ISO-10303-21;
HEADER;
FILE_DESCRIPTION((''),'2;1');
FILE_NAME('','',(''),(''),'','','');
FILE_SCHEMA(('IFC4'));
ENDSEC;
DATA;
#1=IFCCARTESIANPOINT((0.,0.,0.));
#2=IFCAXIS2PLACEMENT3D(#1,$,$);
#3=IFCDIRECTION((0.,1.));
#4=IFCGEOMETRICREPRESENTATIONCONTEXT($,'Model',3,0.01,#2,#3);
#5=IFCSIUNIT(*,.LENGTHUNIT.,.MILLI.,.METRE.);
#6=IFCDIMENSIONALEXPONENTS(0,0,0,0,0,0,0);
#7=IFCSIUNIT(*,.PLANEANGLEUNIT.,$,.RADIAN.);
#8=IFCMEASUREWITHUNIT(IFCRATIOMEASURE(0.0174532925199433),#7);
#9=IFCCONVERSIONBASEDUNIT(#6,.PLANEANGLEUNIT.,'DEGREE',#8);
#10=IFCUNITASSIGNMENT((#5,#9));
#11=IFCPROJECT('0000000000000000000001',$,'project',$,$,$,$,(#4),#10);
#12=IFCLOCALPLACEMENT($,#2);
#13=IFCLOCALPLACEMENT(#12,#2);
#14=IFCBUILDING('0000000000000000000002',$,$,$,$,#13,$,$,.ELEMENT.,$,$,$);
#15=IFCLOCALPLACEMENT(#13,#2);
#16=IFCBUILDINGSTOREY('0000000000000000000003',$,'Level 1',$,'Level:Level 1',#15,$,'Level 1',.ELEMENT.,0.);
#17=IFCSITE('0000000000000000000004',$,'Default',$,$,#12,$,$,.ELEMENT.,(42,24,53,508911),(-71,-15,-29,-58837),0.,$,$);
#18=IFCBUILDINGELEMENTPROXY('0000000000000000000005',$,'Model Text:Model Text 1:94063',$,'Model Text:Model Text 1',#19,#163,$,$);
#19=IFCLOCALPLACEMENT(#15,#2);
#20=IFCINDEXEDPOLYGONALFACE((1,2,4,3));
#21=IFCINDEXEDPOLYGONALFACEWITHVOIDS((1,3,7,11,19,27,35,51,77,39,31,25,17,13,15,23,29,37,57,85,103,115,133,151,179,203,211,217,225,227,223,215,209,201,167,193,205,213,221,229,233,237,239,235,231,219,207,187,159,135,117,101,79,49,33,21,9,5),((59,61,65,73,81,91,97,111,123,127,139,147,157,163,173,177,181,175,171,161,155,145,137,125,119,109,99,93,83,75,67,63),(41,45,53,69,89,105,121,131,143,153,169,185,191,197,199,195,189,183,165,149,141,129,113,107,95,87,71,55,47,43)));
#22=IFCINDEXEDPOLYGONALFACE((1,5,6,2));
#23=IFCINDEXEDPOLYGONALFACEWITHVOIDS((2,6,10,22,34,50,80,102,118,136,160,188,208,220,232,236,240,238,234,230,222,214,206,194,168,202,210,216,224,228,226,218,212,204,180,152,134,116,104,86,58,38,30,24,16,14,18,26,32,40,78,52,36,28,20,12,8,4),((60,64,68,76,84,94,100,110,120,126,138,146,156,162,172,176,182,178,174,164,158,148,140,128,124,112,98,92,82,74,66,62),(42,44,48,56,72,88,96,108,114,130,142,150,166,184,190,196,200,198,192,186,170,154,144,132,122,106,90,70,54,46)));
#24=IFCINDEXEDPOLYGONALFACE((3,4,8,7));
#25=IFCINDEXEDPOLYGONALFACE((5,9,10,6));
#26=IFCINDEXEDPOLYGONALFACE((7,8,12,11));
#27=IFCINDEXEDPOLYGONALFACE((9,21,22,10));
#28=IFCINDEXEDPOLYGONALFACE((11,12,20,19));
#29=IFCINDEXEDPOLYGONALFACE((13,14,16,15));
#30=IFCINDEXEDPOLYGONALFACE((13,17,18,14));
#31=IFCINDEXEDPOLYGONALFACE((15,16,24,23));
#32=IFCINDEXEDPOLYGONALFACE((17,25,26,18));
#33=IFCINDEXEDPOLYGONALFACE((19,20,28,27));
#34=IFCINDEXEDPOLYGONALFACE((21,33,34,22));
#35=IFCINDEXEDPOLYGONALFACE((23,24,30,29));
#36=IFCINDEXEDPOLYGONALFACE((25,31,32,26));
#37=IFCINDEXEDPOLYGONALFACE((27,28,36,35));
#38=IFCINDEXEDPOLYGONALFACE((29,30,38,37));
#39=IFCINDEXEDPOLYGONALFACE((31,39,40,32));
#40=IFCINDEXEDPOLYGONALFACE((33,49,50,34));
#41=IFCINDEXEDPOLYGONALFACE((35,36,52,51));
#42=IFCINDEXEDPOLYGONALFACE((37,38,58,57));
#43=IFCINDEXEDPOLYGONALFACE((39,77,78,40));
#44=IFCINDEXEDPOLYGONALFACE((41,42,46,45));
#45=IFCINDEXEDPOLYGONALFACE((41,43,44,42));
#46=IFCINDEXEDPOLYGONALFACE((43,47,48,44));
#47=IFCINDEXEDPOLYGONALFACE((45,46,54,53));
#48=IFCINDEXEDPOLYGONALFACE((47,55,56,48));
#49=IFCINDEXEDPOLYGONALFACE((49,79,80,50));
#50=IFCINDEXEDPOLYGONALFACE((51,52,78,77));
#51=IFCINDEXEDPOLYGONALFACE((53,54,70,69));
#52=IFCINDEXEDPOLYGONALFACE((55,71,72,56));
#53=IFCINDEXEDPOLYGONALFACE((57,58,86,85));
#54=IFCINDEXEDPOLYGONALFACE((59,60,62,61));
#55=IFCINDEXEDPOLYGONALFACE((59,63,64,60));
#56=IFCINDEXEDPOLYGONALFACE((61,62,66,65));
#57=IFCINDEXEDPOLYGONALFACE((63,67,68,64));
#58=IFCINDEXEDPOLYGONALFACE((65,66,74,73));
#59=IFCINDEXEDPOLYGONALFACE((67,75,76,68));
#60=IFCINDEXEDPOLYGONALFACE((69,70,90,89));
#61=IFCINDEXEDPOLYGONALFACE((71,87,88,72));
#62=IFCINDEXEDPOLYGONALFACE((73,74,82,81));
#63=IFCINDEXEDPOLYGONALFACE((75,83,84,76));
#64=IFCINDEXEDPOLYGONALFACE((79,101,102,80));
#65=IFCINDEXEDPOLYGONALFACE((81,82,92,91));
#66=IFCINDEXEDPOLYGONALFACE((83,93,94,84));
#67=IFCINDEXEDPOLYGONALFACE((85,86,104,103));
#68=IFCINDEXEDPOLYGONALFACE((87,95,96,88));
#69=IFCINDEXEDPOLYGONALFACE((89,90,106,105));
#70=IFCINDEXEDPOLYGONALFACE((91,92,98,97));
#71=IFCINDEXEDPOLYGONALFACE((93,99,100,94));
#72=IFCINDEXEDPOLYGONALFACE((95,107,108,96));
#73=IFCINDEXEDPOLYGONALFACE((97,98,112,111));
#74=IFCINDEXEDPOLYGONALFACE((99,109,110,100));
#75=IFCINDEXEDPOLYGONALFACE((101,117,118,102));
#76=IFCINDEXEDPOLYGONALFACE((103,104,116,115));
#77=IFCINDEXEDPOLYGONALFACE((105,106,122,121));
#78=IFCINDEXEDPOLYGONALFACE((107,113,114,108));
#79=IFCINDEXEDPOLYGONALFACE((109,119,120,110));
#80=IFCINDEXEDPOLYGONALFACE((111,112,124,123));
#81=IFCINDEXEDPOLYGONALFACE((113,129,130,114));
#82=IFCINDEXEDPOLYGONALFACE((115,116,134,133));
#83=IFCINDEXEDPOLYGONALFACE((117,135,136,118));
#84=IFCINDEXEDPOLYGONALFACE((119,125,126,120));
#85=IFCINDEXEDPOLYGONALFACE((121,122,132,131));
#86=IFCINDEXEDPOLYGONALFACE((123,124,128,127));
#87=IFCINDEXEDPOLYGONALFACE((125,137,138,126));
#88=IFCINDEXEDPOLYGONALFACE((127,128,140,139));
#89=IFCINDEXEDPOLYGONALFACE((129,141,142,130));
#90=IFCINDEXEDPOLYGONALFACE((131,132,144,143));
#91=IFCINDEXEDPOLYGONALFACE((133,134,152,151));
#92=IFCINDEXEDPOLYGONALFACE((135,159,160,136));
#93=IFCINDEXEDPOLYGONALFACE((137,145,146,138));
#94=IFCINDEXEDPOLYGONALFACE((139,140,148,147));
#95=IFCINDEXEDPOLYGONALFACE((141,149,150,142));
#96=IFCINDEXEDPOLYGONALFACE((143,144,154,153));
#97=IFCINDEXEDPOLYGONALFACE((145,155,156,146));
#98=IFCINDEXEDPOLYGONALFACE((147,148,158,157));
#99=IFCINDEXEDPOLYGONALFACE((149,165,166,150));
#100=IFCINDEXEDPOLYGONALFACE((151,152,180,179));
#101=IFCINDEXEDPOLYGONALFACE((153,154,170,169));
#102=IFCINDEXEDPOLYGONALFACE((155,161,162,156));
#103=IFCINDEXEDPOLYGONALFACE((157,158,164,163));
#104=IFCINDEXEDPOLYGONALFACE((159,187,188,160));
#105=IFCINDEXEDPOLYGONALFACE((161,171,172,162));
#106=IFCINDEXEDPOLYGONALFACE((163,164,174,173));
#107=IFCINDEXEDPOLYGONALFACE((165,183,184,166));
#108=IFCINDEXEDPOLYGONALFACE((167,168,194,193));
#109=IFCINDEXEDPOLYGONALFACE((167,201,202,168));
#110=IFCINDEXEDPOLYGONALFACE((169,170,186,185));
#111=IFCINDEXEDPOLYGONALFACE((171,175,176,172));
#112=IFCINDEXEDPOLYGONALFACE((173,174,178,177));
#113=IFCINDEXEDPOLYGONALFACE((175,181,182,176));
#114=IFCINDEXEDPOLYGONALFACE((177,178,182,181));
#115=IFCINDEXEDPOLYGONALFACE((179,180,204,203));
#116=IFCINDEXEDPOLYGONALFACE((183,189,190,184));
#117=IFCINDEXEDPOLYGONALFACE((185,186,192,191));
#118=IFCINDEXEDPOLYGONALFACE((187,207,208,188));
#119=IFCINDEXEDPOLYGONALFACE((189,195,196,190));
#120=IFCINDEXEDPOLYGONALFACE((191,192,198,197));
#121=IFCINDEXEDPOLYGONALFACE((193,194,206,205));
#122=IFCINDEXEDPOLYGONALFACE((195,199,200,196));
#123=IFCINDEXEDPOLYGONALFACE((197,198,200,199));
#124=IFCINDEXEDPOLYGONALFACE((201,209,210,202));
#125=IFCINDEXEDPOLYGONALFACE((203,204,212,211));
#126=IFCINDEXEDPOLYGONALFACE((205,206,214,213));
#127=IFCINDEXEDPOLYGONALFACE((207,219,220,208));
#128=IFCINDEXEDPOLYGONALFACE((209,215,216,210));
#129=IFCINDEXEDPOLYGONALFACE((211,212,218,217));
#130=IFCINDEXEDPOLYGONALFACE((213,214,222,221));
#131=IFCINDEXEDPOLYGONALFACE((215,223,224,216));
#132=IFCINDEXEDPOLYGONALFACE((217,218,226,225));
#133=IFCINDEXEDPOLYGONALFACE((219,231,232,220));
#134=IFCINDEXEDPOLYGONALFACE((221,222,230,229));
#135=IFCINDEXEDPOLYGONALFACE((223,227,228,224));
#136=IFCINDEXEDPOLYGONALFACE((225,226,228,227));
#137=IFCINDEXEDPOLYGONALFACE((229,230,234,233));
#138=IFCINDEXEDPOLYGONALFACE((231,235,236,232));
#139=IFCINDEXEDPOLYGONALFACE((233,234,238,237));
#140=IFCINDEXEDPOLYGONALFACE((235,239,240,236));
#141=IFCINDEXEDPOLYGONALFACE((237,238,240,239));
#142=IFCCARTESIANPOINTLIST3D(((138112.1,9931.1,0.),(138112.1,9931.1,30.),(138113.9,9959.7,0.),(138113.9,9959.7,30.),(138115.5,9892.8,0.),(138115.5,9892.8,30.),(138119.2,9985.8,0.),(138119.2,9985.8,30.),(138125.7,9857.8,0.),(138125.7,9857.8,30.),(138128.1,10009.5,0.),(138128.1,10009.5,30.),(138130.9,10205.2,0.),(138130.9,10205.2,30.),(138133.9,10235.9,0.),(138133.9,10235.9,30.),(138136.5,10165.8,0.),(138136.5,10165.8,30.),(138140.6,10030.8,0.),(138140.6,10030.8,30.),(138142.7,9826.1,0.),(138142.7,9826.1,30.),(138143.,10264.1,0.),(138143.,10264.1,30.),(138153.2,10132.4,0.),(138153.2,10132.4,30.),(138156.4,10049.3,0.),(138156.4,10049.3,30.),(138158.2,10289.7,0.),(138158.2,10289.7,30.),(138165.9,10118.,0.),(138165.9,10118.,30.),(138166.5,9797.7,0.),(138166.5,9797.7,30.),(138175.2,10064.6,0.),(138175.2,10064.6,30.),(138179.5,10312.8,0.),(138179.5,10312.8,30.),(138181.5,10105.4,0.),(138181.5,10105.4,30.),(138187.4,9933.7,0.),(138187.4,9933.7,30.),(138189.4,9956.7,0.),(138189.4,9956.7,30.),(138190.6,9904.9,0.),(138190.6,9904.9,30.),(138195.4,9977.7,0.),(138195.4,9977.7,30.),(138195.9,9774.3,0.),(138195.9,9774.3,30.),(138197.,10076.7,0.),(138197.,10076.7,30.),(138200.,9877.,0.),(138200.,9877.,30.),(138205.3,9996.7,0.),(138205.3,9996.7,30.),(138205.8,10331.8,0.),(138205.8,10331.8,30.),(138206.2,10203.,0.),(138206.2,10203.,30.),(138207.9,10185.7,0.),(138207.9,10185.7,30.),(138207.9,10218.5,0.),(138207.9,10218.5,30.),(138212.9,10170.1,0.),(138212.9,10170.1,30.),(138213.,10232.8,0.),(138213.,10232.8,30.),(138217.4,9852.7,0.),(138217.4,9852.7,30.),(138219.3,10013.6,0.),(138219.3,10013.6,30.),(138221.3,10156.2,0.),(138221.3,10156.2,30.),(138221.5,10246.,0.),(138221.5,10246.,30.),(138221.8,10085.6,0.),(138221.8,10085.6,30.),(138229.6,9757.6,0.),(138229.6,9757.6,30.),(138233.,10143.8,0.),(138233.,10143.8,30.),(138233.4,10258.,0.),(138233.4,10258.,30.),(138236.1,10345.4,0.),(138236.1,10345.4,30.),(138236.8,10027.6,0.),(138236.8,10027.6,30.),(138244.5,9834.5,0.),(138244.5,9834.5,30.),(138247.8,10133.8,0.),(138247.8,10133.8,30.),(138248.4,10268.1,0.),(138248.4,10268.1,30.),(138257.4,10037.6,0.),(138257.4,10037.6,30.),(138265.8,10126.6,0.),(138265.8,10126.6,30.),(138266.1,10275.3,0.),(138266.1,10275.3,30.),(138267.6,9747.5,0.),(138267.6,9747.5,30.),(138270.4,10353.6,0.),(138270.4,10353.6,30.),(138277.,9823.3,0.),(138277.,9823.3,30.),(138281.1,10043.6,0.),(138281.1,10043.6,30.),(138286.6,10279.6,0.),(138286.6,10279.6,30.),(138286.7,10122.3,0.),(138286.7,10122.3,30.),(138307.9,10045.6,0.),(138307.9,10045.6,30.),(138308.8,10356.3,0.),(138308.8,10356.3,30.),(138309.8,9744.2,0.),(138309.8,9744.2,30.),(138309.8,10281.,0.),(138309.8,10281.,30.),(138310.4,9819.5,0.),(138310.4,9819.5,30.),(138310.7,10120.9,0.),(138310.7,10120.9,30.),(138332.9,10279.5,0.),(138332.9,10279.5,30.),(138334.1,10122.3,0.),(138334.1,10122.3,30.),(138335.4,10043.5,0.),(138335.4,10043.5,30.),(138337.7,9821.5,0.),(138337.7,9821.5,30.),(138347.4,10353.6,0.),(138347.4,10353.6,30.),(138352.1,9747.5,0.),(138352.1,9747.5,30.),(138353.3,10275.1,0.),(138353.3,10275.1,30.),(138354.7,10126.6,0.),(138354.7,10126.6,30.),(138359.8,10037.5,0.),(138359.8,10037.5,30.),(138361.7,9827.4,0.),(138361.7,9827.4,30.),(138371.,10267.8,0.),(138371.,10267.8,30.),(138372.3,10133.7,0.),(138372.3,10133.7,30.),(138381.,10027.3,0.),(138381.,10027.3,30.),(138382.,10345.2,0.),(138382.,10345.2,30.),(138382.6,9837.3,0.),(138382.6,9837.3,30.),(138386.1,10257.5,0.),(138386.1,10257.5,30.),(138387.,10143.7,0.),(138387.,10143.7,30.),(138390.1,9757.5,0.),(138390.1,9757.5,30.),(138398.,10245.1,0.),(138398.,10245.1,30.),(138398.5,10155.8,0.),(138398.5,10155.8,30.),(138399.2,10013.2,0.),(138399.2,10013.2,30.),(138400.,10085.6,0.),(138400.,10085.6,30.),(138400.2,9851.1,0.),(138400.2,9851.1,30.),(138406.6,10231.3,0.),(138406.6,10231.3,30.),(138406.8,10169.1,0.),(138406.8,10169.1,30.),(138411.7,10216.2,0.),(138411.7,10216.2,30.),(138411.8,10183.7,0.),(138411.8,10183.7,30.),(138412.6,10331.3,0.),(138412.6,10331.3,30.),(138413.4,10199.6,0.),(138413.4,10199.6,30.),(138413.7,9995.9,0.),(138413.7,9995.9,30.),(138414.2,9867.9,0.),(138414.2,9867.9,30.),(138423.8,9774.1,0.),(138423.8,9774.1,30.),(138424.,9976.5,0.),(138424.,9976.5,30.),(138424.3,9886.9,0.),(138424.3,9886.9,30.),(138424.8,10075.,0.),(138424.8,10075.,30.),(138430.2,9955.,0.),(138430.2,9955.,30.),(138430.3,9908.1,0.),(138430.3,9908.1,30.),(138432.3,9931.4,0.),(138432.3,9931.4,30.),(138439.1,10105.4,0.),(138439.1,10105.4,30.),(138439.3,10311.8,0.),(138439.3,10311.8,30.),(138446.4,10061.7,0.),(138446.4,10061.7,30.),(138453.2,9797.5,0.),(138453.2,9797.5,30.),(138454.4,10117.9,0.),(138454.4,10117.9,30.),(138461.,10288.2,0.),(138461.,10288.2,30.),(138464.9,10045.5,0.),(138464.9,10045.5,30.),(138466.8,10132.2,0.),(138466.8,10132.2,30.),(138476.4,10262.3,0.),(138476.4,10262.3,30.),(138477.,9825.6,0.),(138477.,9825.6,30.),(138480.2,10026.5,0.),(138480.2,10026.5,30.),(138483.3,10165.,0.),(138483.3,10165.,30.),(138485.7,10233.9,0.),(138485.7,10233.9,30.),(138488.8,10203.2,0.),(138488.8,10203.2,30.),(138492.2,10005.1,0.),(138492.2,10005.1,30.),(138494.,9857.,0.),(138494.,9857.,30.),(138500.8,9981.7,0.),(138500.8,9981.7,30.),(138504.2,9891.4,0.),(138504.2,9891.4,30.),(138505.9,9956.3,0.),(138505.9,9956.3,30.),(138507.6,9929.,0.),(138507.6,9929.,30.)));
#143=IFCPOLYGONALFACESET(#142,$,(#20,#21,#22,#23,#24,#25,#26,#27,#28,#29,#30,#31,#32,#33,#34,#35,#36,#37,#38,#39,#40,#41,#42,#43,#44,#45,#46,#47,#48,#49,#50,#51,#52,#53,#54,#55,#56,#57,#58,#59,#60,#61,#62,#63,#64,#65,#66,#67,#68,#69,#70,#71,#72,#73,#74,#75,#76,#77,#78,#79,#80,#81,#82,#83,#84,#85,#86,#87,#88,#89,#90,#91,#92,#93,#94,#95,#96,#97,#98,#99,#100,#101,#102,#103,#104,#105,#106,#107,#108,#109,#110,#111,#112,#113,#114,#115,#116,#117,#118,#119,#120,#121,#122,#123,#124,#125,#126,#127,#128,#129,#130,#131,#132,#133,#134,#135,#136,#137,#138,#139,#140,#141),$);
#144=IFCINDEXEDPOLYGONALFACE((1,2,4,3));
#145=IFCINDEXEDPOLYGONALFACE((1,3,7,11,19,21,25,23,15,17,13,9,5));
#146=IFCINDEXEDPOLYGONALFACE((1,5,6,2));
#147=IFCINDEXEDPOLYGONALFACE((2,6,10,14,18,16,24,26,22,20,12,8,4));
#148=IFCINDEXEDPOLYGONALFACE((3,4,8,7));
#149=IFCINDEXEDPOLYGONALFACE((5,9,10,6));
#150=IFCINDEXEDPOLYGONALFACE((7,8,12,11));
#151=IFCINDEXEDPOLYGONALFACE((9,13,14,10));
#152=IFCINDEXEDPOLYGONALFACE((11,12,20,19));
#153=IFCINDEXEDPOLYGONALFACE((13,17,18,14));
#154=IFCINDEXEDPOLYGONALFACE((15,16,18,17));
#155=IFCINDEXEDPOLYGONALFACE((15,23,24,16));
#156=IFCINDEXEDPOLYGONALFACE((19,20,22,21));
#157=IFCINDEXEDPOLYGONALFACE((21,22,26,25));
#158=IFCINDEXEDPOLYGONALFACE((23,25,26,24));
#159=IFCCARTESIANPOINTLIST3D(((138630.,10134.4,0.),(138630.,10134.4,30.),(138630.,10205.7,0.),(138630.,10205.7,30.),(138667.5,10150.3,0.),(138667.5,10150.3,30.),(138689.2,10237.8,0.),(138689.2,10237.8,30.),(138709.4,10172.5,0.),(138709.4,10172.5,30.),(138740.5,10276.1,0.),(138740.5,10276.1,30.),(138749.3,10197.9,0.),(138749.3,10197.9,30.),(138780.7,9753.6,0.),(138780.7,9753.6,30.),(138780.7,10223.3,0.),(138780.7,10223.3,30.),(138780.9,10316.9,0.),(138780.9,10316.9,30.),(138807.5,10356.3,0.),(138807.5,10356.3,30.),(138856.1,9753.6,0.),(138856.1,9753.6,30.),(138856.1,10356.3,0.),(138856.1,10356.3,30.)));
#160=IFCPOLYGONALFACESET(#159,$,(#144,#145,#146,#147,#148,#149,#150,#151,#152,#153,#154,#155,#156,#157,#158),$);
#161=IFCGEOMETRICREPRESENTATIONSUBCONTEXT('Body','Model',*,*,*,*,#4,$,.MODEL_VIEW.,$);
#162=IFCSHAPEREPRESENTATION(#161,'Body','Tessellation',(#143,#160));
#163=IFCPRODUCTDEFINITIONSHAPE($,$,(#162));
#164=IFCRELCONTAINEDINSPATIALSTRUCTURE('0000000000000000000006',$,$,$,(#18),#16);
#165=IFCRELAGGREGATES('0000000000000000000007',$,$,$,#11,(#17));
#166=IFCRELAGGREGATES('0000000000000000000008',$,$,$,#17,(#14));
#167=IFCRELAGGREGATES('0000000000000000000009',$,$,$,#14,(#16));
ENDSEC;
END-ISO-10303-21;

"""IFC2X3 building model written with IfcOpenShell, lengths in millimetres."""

from ifc_helpers import new_model, entity, si_unit, converted_unit, direction, frame, origin, place, context, subcontext, project, spatial, polyline, outline, extrude, element, save


model = new_model("IFC2X3")

# Units and contexts
model_context = context("Model", 3, precision=0.01, world=origin(), true_north=direction((0.0, 1.0)))
body_context = subcontext(model_context, "Body", "Model", "MODEL_VIEW")
ifc_project = project(units=[si_unit("LENGTHUNIT", "METRE", prefix="MILLI"), converted_unit("PLANEANGLEUNIT", "DEGREE", entity("IfcRatioMeasure", 0.0174532925199433), si_unit("PLANEANGLEUNIT", "RADIAN"), dimensions=[0, 0, 0, 0, 0, 0, 0])], contexts=[model_context])

# Site, building, storey
site_placement = place(None, origin())
site = spatial("IfcSite", under=ifc_project, at=site_placement, Name="Default", CompositionType="ELEMENT", RefLatitude=(42, 24, 53, 508911), RefLongitude=(-71, -15, -29, -58837), RefElevation=0.0)
building_placement = place(site_placement, origin())
building = spatial("IfcBuilding", under=site, at=building_placement, CompositionType="ELEMENT")
storey_placement = place(building_placement, origin())
storey = spatial("IfcBuildingStorey", under=building, at=storey_placement, Name="Level 1", ObjectType="Level:Level 1", LongName="Level 1", CompositionType="ELEMENT", Elevation=0.0)

# Building element proxy
proxy_1_placement = place(storey_placement, origin())
element("IfcBuildingElementProxy", 1, at=proxy_1_placement, inside=storey, Name="Model Text:Model Text 1:94063", ObjectType="Model Text:Model Text 1", context=body_context, shape_type="SweptSolid", body=[
    extrude(outline(polyline([(74.3, -53.8), (100.6, -53.8), (125.3, -49.8), (148.1, -41.8), (169.2, -29.7), (188.1, -13.8), (204.5, 5.5), (218.4, 28.3), (229.7, 54.7), (239.4, 91.9), (241.6, 128.3), (236.2, 163.8), (223.4, 198.6), (203.6, 230.5), (177.5, 257.6), (145.1, 279.9), (106.4, 297.2), (65.5, 308.4), (26.4, 311.7), (-11.0, 307.4), (-46.5, 295.4), (-78.4, 276.8), (-105.0, 253.1), (-126.2, 224.1), (-142.0, 189.8), (-149.6, 163.5), (-153.3, 137.9), (-153.1, 113.0), (-149.0, 88.8), (-141.0, 65.8), (-129.1, 44.3), (-113.3, 24.5), (-93.5, 6.2), (-137.0, 0.7), (-155.5, -5.9), (-172.0, -15.2), (-198.6, -40.6), (-216.7, -74.6), (-224.1, -104.7), (-225.0, -134.5), (-219.1, -164.1), (-206.7, -193.5), (-188.1, -220.9), (-164.0, -244.3), (-134.2, -263.9), (-98.8, -279.5), (-61.8, -289.8), (-26.7, -293.7), (6.5, -291.1), (37.6, -282.0), (65.4, -267.5), (88.3, -248.5), (106.4, -225.0), (119.6, -197.1), (127.6, -158.1), (123.1, -121.0), (116.1, -103.3), (105.6, -86.1), (74.3, -53.8)]), holes=[polyline([(49.4, -169.7), (42.6, -183.7), (33.0, -195.4), (20.5, -205.0), (5.3, -212.3), (-12.2, -216.7), (-31.3, -217.5), (-52.0, -214.7), (-74.4, -208.2), (-95.6, -199.0), (-113.4, -188.0), (-127.6, -175.1), (-138.3, -160.4), (-145.4, -144.7), (-148.8, -128.8), (-148.5, -112.8), (-144.5, -96.7), (-137.6, -82.3), (-128.0, -70.2), (-115.7, -60.4), (-100.8, -52.9), (-83.6, -48.5), (-64.6, -47.7), (-43.8, -50.6), (-21.3, -57.2), (0.8, -66.6), (19.1, -77.7), (33.6, -90.5), (44.2, -105.0), (51.0, -120.5), (54.2, -136.4), (53.7, -152.8), (49.4, -169.7)]), polyline([(157.9, 77.5), (148.2, 56.6), (135.5, 38.8), (119.8, 24.3), (100.9, 13.0), (79.8, 5.8), (57.0, 3.3), (32.7, 5.7), (6.7, 12.8), (-18.5, 24.0), (-39.4, 37.9), (-56.0, 54.6), (-68.3, 74.1), (-76.1, 95.2), (-79.3, 116.9), (-77.9, 139.3), (-71.9, 162.2), (-62.2, 183.5), (-49.4, 201.4), (-33.6, 215.9), (-14.7, 227.0), (6.6, 234.1), (29.5, 236.4), (54.2, 233.8), (80.5, 226.5), (110.7, 211.7), (137.5, 190.2), (156.9, 164.0), (165.1, 135.2), (164.6, 105.7), (157.9, 77.5)])]), frame((138309.9, 10059.9, 0.0), z_axis=(0.0, 0.0, 1.0), x_axis=(-0.941552, -0.336867, 0.0)), (0.0, 0.0, 1.0), 30.0),
    extrude(outline(polyline([(-410.6, -111.6), (192.1, -111.6), (192.1, -63.1), (152.7, -36.4), (111.9, 4.0), (73.6, 55.2), (41.4, 114.4), (-29.8, 114.4), (-13.9, 77.0), (8.3, 35.1), (33.7, -4.8), (59.1, -36.3), (-410.6, -36.3), (-410.6, -111.6)])), frame((138744.5, 10164.2, 0.0), z_axis=(0.0, 0.0, 1.0), x_axis=(0.0, 1.0, 0.0)), (0.0, 0.0, 1.0), 30.0),
])

save(model, "model.ifc")
